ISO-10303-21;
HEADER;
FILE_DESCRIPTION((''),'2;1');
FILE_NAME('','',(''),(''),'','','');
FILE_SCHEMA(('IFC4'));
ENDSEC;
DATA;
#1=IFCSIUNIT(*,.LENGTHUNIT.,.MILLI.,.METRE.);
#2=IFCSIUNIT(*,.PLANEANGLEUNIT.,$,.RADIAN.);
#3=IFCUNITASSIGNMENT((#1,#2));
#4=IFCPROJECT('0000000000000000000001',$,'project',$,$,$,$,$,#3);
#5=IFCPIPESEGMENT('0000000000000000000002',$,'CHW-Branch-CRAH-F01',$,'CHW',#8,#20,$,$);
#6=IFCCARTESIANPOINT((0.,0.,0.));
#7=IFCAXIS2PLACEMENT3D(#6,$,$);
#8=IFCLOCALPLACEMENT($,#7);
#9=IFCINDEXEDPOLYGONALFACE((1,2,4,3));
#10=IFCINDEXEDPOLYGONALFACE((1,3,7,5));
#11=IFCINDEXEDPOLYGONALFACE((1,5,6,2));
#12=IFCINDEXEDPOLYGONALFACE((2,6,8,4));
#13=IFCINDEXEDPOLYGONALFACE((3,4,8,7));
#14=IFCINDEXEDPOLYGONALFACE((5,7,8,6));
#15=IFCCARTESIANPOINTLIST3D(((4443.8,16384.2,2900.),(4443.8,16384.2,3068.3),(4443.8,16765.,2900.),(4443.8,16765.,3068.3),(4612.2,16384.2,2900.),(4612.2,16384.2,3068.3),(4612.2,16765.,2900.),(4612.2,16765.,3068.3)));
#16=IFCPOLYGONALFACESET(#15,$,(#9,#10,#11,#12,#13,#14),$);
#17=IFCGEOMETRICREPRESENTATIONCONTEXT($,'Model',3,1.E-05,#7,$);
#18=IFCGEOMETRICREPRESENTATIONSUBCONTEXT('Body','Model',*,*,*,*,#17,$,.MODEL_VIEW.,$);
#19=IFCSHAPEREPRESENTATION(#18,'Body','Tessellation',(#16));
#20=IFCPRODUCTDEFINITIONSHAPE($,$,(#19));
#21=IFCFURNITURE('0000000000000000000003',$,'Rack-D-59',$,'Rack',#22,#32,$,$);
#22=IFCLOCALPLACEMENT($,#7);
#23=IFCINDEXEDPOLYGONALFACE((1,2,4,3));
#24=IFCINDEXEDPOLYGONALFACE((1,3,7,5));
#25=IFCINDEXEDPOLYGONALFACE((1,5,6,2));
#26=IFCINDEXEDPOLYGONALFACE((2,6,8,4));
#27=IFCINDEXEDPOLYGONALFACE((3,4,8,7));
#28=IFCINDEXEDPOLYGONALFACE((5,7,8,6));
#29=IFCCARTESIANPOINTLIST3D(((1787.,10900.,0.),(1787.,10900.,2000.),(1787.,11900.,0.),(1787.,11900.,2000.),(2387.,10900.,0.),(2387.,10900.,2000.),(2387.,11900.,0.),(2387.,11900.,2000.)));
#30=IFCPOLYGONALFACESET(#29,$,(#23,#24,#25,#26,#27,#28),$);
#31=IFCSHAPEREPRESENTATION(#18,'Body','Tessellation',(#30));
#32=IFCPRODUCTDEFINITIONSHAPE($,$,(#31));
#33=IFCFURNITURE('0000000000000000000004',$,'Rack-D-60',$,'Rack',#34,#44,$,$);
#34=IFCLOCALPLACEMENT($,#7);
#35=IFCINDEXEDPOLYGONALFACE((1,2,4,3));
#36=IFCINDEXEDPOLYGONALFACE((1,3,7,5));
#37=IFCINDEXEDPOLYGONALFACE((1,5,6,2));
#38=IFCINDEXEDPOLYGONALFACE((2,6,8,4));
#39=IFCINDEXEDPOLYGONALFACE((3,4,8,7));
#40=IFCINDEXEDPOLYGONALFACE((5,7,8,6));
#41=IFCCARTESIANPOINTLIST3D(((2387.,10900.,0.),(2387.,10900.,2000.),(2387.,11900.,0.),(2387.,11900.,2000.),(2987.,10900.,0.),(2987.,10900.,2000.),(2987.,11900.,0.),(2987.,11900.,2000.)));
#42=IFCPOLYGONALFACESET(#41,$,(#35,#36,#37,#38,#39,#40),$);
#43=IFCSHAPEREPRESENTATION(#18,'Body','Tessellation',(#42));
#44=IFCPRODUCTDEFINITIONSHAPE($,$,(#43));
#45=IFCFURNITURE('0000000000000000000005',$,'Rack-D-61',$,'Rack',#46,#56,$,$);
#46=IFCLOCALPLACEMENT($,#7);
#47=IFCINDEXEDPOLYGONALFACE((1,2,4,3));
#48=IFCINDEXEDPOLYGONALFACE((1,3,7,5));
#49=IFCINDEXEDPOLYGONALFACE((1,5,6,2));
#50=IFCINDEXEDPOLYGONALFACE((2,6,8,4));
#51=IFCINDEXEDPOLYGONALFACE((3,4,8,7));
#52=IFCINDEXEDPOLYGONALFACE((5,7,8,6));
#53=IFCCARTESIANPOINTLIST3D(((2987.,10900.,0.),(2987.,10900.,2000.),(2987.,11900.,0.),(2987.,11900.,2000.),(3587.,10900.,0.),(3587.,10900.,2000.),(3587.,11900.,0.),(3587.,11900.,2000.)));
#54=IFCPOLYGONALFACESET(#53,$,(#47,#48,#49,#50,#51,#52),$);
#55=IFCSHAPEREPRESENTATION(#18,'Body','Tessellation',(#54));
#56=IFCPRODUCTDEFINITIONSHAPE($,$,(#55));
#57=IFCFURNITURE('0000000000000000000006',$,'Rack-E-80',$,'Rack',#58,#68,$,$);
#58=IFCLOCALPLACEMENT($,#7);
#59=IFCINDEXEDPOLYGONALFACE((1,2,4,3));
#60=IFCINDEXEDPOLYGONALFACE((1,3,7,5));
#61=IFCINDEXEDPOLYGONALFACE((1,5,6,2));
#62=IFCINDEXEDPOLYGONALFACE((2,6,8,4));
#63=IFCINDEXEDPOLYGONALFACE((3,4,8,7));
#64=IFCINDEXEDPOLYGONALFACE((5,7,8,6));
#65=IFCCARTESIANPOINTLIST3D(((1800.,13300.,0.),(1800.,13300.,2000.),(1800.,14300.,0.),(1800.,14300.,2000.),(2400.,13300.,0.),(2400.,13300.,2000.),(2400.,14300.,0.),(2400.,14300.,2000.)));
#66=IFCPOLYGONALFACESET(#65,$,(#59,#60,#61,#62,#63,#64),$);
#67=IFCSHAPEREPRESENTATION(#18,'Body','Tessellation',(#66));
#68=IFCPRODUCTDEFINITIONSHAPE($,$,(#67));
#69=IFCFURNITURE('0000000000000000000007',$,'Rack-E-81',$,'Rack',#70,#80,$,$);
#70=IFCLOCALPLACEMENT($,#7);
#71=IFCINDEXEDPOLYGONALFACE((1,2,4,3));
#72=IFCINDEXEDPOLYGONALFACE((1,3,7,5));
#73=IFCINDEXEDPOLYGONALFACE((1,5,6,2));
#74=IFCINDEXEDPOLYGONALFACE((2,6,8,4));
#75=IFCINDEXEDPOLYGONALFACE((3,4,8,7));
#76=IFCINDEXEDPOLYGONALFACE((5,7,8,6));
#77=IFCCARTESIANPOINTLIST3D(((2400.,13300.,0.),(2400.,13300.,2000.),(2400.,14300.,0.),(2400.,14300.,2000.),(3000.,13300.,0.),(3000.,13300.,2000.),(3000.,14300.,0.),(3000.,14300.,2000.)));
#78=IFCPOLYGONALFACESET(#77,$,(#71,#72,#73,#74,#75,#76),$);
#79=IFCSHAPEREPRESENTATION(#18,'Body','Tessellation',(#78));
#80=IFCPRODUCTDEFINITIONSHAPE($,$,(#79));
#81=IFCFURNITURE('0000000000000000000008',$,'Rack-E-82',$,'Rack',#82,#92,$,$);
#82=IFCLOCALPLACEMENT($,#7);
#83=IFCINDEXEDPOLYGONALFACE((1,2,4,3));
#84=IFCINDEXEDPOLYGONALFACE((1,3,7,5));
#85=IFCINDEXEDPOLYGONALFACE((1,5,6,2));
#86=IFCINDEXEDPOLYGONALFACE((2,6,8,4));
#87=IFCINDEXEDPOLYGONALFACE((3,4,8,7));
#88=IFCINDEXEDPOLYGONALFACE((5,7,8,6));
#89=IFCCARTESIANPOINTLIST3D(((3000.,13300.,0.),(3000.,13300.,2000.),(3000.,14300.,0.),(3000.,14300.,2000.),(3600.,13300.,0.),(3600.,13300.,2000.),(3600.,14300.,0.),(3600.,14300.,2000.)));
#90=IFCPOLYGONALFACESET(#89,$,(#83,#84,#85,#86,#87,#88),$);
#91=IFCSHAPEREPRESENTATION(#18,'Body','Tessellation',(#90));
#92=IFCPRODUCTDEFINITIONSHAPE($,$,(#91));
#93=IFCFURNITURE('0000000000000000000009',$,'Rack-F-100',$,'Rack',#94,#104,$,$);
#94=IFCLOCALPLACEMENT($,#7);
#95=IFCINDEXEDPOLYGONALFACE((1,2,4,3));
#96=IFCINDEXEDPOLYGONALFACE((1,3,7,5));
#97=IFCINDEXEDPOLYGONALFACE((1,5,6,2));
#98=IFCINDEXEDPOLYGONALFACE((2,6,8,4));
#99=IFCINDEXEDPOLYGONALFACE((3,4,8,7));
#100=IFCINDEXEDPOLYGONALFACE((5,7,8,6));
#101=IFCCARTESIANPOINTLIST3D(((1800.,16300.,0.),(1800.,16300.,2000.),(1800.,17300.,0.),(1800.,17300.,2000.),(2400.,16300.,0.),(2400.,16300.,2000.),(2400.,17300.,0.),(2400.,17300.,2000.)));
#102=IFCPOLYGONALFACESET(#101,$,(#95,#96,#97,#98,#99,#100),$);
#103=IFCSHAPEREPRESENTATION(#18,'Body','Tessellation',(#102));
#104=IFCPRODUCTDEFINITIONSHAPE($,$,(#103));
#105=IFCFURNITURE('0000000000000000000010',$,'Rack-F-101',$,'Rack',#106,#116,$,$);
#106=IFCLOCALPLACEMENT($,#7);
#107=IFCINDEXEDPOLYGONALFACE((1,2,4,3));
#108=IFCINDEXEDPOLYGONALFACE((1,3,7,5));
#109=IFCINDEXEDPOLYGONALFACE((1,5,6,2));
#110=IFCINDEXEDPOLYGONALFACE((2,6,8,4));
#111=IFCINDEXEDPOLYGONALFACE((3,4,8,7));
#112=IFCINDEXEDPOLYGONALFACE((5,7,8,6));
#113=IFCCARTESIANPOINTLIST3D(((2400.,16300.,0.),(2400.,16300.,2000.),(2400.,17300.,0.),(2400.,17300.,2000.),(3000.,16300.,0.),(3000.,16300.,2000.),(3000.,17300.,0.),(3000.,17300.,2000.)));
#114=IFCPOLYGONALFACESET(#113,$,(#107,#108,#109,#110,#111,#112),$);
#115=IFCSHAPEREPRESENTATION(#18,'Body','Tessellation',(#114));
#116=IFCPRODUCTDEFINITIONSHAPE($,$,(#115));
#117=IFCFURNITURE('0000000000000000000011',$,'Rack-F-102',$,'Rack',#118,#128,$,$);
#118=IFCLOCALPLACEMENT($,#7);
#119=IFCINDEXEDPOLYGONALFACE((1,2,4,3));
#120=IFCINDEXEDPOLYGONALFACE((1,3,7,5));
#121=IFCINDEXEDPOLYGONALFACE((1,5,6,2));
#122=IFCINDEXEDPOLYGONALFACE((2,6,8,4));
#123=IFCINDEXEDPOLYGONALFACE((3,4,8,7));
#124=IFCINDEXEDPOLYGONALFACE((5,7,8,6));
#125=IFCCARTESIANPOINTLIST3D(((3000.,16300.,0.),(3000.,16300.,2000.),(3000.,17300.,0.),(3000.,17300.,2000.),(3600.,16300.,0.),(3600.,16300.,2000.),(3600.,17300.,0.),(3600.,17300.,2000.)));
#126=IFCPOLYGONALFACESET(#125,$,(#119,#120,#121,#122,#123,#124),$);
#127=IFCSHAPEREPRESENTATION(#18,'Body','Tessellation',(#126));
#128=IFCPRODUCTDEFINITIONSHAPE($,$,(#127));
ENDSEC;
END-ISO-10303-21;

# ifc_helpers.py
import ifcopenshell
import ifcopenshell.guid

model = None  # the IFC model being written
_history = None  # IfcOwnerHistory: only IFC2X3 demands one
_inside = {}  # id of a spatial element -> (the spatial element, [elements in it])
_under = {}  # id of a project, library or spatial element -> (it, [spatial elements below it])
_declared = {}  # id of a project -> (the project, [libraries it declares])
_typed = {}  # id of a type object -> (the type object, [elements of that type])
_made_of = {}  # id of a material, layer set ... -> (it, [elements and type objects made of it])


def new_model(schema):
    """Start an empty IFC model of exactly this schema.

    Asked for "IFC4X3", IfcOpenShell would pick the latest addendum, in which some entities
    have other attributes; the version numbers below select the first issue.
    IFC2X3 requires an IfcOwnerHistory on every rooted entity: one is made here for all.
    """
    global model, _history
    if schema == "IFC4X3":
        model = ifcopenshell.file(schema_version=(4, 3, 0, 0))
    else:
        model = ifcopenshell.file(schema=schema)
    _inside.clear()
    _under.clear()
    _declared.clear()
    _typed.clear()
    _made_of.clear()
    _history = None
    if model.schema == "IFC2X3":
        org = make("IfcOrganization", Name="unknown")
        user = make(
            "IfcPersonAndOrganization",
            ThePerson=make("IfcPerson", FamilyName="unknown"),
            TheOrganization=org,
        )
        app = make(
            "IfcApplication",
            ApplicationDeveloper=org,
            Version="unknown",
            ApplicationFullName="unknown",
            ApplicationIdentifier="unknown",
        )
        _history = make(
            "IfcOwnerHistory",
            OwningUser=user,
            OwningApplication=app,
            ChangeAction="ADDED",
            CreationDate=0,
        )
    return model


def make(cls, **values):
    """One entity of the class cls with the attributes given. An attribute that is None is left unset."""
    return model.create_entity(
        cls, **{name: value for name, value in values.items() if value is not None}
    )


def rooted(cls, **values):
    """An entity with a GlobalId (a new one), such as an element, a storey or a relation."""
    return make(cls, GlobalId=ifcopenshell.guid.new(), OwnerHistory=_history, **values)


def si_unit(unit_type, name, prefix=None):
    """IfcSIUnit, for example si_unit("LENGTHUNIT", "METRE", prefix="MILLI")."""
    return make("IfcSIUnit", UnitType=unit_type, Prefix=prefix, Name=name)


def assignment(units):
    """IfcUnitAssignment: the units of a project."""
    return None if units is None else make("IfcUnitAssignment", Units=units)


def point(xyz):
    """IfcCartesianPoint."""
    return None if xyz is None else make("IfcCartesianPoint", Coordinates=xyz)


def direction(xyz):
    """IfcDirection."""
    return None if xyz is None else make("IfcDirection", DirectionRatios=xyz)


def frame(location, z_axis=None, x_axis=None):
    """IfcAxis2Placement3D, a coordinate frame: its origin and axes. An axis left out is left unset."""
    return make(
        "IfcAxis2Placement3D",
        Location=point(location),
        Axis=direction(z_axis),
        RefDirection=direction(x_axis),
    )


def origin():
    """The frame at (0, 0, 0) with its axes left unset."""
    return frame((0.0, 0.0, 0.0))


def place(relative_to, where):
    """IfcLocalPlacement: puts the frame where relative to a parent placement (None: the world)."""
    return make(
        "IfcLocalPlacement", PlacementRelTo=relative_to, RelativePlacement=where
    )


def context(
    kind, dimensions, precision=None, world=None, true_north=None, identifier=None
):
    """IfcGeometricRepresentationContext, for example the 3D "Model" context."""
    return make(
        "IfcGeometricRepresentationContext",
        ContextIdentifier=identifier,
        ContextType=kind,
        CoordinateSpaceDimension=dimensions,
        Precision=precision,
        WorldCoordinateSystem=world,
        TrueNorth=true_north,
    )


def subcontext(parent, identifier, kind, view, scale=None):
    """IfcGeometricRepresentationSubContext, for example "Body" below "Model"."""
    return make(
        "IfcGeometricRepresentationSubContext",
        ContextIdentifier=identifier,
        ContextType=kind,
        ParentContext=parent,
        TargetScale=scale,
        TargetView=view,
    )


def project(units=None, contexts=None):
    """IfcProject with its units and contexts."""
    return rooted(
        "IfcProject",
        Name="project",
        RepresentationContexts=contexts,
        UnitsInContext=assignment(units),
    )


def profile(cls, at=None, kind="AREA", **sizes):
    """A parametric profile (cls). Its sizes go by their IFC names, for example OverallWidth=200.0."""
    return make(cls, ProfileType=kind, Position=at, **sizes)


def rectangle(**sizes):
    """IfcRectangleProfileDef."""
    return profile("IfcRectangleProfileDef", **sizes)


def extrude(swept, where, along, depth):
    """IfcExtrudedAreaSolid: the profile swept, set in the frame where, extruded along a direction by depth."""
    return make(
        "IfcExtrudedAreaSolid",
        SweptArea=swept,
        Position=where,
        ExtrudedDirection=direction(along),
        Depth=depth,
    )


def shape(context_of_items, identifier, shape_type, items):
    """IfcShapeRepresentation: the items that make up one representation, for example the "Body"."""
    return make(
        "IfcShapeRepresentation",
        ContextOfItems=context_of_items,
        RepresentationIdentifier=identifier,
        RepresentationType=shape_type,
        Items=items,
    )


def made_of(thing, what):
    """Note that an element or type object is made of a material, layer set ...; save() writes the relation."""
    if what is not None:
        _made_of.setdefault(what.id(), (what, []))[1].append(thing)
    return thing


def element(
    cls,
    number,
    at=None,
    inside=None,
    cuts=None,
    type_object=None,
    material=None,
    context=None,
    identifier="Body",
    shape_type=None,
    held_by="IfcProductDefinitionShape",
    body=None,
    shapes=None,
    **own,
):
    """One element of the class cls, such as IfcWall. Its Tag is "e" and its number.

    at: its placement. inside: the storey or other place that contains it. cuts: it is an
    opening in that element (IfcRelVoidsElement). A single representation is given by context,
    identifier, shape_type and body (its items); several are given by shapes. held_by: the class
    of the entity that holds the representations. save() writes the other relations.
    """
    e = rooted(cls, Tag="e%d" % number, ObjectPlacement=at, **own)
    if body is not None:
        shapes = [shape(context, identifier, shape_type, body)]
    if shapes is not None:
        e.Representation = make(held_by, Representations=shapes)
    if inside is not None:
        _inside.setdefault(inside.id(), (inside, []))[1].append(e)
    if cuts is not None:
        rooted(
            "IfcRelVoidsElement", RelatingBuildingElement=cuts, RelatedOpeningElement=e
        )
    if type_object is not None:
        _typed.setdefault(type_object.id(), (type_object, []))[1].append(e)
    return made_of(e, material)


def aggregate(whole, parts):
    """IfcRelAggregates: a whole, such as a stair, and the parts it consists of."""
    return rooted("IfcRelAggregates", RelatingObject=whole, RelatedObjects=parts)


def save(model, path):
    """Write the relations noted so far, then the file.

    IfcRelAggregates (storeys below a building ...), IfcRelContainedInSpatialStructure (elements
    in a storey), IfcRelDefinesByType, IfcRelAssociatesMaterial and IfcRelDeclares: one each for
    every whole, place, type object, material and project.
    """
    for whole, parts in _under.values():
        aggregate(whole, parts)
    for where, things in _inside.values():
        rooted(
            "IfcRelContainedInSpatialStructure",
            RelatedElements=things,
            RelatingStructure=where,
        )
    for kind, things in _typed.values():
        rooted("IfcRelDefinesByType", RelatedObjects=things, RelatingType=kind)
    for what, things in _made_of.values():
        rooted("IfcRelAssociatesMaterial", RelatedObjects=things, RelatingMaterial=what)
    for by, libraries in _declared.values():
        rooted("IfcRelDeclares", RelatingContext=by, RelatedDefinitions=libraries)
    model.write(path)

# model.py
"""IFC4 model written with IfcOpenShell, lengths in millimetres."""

from ifc_helpers import new_model, si_unit, frame, origin, place, context, subcontext, project, rectangle, extrude, element, save


model = new_model("IFC4")

# Units and contexts
model_context = context("Model", 3, precision=1e-05, world=origin())
body_context = subcontext(model_context, "Body", "Model", "MODEL_VIEW")
ifc_project = project(units=[si_unit("LENGTHUNIT", "METRE", prefix="MILLI"), si_unit("PLANEANGLEUNIT", "RADIAN")])

# Pipe segment
pipe_segment_1_placement = place(None, frame((4528.0, 16574.6, 2900.0)))
element("IfcPipeSegment", 1, at=pipe_segment_1_placement, Name="CHW-Branch-CRAH-F01", ObjectType="CHW", context=body_context, shape_type="SweptSolid", body=[
    extrude(rectangle(XDim=168.3, YDim=380.8), None, (0.0, 0.0, 1.0), 168.3),
])

# Furniture
for number, where, name in (
    (2, (2087.0, 11400.0, 0.0), "Rack-D-59"),
    (3, (2687.0, 11400.0, 0.0), "Rack-D-60"),
    (4, (3287.0, 11400.0, 0.0), "Rack-D-61"),
    (5, (2100.0, 13800.0, 0.0), "Rack-E-80"),
    (6, (2700.0, 13800.0, 0.0), "Rack-E-81"),
    (7, (3300.0, 13800.0, 0.0), "Rack-E-82"),
    (8, (2100.0, 16800.0, 0.0), "Rack-F-100"),
    (9, (2700.0, 16800.0, 0.0), "Rack-F-101"),
    (10, (3300.0, 16800.0, 0.0), "Rack-F-102"),
):
    element("IfcFurniture", number, at=place(None, frame(where)), Name=name, ObjectType="Rack", context=body_context, shape_type="SweptSolid", body=[
        extrude(rectangle(XDim=600.0, YDim=1000.0), None, (0.0, 0.0, 1.0), 2000.0),
    ])

save(model, "model.ifc")
